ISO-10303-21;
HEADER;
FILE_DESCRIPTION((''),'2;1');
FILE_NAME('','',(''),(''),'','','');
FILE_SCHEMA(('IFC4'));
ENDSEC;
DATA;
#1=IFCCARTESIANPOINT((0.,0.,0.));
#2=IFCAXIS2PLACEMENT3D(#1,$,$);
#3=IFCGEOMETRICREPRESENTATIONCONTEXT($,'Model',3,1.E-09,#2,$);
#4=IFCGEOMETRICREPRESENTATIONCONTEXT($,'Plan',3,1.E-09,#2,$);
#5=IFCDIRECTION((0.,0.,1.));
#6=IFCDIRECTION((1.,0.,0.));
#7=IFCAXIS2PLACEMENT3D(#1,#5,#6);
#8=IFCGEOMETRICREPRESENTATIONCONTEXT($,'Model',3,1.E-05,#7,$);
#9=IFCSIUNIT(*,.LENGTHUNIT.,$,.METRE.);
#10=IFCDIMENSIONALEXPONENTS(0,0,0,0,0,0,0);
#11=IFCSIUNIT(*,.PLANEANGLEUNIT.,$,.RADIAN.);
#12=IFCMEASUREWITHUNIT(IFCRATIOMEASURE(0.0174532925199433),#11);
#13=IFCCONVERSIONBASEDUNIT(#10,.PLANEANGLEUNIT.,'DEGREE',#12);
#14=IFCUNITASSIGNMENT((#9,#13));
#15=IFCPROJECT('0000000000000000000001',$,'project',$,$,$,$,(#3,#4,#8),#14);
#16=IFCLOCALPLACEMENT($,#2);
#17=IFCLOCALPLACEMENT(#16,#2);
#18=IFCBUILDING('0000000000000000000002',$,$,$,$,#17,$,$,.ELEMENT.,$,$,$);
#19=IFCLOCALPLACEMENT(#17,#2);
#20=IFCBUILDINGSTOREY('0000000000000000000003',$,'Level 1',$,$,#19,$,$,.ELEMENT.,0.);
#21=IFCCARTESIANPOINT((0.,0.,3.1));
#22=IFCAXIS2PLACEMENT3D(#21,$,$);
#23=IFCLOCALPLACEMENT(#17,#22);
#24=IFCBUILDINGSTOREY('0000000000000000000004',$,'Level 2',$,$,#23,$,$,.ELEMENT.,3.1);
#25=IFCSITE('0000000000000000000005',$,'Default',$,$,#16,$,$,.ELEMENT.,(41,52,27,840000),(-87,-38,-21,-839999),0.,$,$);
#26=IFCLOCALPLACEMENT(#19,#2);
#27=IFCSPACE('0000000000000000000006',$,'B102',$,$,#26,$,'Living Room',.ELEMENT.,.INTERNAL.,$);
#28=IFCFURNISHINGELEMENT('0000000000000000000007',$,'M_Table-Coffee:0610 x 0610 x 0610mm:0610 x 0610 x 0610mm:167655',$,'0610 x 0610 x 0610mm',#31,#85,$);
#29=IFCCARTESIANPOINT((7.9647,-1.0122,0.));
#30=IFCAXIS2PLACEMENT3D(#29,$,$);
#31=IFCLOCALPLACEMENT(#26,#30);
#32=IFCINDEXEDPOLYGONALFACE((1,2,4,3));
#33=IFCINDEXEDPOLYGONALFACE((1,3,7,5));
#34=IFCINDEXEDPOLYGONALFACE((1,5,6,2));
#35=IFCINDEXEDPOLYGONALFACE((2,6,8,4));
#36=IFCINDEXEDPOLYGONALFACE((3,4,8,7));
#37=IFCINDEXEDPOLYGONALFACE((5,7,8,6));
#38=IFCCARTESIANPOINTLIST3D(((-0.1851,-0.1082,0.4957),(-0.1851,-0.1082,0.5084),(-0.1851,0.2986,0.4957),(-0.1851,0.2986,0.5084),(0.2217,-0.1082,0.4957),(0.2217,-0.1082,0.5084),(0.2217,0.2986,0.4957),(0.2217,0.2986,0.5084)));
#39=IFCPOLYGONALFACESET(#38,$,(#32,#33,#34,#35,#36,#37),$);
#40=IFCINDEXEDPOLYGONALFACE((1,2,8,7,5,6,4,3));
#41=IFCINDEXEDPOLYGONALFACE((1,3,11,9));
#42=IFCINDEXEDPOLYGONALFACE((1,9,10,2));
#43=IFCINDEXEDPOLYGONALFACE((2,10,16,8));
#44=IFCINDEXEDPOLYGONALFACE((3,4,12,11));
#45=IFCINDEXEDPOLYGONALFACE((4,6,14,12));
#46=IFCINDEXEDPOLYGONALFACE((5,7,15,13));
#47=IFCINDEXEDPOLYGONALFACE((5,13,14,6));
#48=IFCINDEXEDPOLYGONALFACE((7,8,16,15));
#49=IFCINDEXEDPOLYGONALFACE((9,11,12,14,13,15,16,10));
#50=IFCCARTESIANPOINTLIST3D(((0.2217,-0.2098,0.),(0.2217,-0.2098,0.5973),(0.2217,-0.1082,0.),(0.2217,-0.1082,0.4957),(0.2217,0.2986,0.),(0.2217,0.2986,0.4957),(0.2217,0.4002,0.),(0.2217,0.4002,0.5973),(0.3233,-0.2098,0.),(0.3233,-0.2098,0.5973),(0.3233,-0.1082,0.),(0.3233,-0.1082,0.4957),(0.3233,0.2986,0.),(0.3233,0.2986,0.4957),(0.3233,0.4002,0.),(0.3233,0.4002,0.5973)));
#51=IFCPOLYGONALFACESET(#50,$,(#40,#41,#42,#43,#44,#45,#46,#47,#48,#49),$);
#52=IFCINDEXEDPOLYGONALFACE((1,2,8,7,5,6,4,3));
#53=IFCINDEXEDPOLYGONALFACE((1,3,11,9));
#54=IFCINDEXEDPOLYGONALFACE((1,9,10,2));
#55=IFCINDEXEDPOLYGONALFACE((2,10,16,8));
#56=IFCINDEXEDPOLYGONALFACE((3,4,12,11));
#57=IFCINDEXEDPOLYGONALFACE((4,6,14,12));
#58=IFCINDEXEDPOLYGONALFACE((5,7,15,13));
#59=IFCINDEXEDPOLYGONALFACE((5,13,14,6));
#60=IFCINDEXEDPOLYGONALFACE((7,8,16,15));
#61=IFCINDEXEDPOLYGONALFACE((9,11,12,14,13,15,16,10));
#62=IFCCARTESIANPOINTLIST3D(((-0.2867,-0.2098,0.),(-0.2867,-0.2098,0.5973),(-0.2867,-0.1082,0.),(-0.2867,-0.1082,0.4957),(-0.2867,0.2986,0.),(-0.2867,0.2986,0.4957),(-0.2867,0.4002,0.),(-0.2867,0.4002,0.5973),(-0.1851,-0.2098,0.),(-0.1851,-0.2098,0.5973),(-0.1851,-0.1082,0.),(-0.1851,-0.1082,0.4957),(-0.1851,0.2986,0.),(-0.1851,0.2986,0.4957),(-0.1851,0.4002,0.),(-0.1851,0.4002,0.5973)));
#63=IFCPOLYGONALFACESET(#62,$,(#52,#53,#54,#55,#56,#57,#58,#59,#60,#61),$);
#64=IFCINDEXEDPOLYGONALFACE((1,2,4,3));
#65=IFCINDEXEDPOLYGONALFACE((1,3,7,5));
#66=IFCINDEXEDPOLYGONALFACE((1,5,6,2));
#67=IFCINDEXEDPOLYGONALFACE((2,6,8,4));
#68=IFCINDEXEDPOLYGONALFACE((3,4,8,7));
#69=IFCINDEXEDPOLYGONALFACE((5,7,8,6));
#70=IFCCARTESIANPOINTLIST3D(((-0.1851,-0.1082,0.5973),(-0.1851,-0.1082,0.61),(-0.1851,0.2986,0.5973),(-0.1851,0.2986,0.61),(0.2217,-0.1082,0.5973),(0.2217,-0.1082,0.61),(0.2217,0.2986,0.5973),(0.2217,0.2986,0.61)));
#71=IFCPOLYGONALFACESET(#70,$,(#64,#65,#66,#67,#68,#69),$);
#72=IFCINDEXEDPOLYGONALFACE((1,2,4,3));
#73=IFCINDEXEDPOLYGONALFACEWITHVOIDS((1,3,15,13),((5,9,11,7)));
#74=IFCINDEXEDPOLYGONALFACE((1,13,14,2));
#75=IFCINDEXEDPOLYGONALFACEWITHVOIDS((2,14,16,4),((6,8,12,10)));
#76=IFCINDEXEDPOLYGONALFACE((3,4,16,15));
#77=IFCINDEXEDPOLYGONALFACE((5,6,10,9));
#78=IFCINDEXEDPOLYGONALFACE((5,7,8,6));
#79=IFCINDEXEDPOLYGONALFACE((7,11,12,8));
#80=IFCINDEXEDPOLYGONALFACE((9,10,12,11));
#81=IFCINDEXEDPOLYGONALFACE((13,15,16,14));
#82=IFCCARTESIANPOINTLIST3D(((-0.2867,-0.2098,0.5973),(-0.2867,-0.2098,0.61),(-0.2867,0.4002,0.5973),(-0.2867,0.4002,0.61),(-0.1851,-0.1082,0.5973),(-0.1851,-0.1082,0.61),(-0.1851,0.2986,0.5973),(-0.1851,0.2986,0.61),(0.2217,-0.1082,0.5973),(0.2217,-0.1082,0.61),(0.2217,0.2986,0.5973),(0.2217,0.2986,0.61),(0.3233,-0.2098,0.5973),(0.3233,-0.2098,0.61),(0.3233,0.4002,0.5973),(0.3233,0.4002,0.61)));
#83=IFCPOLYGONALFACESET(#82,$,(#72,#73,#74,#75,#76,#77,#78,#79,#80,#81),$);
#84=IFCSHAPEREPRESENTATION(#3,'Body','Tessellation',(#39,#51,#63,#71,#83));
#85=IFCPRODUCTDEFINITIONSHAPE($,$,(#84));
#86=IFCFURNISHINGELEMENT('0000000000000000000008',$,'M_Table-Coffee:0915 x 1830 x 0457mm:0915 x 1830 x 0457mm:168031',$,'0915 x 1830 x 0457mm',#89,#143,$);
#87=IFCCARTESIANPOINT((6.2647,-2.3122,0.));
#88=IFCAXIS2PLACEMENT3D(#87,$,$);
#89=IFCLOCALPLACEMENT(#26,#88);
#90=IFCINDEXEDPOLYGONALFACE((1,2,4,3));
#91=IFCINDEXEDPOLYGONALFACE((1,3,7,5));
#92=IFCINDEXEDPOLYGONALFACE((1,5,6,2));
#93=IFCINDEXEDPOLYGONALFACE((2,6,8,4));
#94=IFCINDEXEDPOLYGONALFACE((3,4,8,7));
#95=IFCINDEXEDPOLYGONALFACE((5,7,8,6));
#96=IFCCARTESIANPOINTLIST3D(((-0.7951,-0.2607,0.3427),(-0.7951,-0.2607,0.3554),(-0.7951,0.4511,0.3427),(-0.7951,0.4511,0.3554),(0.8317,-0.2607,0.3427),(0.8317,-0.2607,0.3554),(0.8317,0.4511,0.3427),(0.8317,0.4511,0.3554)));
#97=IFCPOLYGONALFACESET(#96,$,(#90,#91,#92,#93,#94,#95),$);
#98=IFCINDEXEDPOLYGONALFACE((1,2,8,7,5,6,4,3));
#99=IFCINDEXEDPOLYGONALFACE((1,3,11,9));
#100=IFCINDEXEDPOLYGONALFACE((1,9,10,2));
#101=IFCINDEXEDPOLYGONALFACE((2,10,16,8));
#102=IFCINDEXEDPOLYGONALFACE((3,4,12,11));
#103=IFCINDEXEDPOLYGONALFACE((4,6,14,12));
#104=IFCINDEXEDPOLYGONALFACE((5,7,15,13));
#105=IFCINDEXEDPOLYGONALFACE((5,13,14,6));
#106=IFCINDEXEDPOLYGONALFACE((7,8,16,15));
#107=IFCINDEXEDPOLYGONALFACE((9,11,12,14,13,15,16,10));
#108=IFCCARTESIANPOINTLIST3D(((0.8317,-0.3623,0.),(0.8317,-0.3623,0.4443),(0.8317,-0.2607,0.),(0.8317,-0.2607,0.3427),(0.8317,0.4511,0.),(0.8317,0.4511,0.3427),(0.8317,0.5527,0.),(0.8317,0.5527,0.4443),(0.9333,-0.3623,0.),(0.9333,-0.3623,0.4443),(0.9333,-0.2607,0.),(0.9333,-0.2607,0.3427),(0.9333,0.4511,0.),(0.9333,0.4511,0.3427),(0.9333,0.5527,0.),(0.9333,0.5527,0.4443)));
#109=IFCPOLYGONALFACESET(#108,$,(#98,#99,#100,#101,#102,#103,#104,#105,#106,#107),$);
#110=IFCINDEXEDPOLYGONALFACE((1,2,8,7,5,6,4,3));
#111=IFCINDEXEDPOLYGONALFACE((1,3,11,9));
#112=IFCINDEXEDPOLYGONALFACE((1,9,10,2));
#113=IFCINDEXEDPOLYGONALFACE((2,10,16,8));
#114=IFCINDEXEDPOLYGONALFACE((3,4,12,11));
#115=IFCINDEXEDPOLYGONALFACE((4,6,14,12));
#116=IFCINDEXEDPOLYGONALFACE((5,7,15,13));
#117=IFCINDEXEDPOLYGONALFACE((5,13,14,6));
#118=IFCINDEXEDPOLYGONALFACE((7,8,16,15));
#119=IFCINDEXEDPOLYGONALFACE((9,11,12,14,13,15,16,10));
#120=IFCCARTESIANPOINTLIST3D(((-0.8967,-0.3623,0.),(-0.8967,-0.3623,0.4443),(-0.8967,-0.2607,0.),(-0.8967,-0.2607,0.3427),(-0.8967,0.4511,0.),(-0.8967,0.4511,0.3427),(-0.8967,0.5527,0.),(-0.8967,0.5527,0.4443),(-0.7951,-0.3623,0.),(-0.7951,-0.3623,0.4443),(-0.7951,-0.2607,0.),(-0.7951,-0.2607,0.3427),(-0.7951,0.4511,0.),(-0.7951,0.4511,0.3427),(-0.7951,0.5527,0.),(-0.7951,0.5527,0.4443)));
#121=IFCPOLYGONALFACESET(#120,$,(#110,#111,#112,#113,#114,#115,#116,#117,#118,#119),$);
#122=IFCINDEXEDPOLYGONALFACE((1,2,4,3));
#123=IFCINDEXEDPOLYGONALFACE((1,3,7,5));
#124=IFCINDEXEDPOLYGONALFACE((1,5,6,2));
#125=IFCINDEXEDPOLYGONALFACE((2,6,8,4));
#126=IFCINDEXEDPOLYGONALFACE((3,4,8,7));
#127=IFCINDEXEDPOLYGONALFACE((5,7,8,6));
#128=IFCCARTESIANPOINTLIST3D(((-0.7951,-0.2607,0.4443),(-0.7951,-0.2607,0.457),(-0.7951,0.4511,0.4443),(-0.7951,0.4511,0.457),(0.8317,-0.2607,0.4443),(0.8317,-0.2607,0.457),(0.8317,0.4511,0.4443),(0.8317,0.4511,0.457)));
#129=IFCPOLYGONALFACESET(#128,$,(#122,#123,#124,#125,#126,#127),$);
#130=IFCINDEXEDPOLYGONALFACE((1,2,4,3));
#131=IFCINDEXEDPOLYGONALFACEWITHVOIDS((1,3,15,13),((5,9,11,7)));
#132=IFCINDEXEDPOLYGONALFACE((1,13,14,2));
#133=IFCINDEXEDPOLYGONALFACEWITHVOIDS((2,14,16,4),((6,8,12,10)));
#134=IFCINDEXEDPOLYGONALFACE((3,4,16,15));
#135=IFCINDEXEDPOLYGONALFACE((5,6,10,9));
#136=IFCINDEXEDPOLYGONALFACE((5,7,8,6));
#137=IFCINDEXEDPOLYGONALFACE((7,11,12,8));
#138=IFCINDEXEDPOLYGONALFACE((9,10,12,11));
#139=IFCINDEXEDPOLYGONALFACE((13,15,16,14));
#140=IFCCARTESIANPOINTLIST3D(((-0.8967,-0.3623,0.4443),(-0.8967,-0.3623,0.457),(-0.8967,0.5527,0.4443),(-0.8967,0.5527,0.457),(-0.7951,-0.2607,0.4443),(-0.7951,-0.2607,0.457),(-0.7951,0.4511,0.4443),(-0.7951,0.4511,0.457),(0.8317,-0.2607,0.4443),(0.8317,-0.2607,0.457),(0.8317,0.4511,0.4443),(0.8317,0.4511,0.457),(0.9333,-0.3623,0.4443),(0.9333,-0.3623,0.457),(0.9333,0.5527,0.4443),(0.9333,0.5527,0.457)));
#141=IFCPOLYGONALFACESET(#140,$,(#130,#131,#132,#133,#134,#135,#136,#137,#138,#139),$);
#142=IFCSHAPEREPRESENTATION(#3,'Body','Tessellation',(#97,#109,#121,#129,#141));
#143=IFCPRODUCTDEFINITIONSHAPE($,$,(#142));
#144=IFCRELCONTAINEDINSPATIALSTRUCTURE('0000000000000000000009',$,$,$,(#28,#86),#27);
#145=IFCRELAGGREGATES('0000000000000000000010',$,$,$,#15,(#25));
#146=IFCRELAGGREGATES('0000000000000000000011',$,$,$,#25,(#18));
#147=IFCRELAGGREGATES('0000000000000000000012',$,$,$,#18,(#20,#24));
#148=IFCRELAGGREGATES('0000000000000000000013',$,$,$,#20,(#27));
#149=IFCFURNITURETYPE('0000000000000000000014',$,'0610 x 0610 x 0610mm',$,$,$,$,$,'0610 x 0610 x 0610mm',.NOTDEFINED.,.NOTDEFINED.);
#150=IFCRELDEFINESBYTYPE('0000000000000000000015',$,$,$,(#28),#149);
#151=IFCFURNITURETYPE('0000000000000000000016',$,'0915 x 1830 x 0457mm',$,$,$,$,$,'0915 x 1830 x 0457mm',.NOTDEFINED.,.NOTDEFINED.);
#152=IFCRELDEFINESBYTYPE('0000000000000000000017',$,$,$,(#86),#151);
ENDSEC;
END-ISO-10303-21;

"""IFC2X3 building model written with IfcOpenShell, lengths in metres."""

from ifc_helpers import new_model, entity, si_unit, converted_unit, frame, origin, origin_with_axes, origin_2d_with_axis, place, context, project, spatial, polyline, rectangle, outline, extrude, source, transform, mapped, type_object, type_shapes, element, save


model = new_model("IFC2X3")

# Units and contexts
model_context_1 = context("Model", 3, precision=1e-09, world=origin())
plan_context = context("Plan", 3, precision=1e-09, world=origin())
model_context_2 = context("Model", 3, precision=1e-05, world=origin_with_axes())
ifc_project = project(units=[si_unit("LENGTHUNIT", "METRE"), converted_unit("PLANEANGLEUNIT", "DEGREE", entity("IfcRatioMeasure", 0.0174532925199433), si_unit("PLANEANGLEUNIT", "RADIAN"), dimensions=[0, 0, 0, 0, 0, 0, 0])], contexts=[model_context_1, plan_context, model_context_2])

# Site, building, storey
site_placement = place(None, origin())
site = spatial("IfcSite", under=ifc_project, at=site_placement, Name="Default", CompositionType="ELEMENT", RefLatitude=(41, 52, 27, 840000), RefLongitude=(-87, -38, -21, -839999), RefElevation=0.0)
building_placement = place(site_placement, origin())
building = spatial("IfcBuilding", under=site, at=building_placement, CompositionType="ELEMENT")
storey_1_placement = place(building_placement, origin())
storey_1 = spatial("IfcBuildingStorey", under=building, at=storey_1_placement, Name="Level 1", CompositionType="ELEMENT", Elevation=0.0)

# Shared definitions
storey_2_placement = place(building_placement, frame((0.0, 0.0, 3.1)))
storey_2 = spatial("IfcBuildingStorey", under=building, at=storey_2_placement, Name="Level 2", CompositionType="ELEMENT", Elevation=3.1)

# Shared definitions
space_1_placement = place(storey_1_placement, origin())
space_1 = spatial("IfcSpace", under=storey_1, at=space_1_placement, Name="B102", LongName="Living Room", CompositionType="ELEMENT", InteriorOrExteriorSpace="INTERNAL")

# Furnishing elements
furniture_type_1 = type_object("IfcFurnitureType", Name="0610 x 0610 x 0610mm", ElementType="0610 x 0610 x 0610mm", AssemblyPlace="NOTDEFINED")
shared_shape_1 = source(origin(), model_context_1, "Body", "SweptSolid", [
    extrude(rectangle(XDim=0.4068, YDim=0.4068, at=origin_2d_with_axis()), frame((0.0183, 0.0952, 0.4957), z_axis=(0.0, 0.0, 1.0), x_axis=(-1.0, 0.0, 0.0)), (0.0, 0.0, 1.0), 0.0127),
    extrude(outline(polyline([(-0.2732, -0.305), (0.324, -0.305), (0.324, 0.305), (-0.2732, 0.305), (-0.2732, 0.2034), (0.2225, 0.2034), (0.2225, -0.2034), (-0.2732, -0.2034), (-0.2732, -0.305)])), frame((0.2217, 0.0952, 0.2732), z_axis=(1.0, 0.0, 0.0), x_axis=(0.0, 0.0, 1.0)), (0.0, 0.0, 1.0), 0.1016),
    extrude(outline(polyline([(-0.305, -0.3241), (0.305, -0.3241), (0.305, 0.2733), (0.2034, 0.2733), (0.2034, -0.2224), (-0.2034, -0.2224), (-0.2034, 0.2733), (-0.305, 0.2733), (-0.305, -0.3241)])), frame((-0.2867, 0.0952, 0.2733), z_axis=(1.0, 0.0, 0.0), x_axis=(0.0, -1.0, 0.0)), (0.0, 0.0, 1.0), 0.1016),
    extrude(rectangle(XDim=0.4068, YDim=0.4068, at=origin_2d_with_axis()), frame((0.0183, 0.0952, 0.5973), z_axis=(0.0, 0.0, 1.0), x_axis=(-1.0, 0.0, 0.0)), (0.0, 0.0, 1.0), 0.0127),
    extrude(outline(polyline([(-0.305, -0.305), (0.305, -0.305), (0.305, 0.305), (-0.305, 0.305), (-0.305, -0.305)]), holes=[polyline([(-0.2034, -0.2034), (-0.2034, 0.2034), (0.2034, 0.2034), (0.2034, -0.2034), (-0.2034, -0.2034)])]), frame((0.0183, 0.0952, 0.5973), z_axis=(0.0, 0.0, 1.0), x_axis=(-1.0, 0.0, 0.0)), (0.0, 0.0, 1.0), 0.0127),
])
type_shapes(furniture_type_1, [shared_shape_1])
for number, where, name in (
    (1, (7.9647, -1.0122, 0.0), "M_Table-Coffee:0610 x 0610 x 0610mm:0610 x 0610 x 0610mm:167655"),
):
    element("IfcFurnishingElement", number, at=place(space_1_placement, frame(where)), inside=space_1, type_object=furniture_type_1, Name=name, ObjectType="0610 x 0610 x 0610mm", context=model_context_1, shape_type="MappedRepresentation", body=[
        mapped(shared_shape_1, transform((0.0, 0.0, 0.0), scale=1.0)),
    ])
furniture_type_2 = type_object("IfcFurnitureType", Name="0915 x 1830 x 0457mm", ElementType="0915 x 1830 x 0457mm", AssemblyPlace="NOTDEFINED")
shared_shape_2 = source(origin(), model_context_1, "Body", "SweptSolid", [
    extrude(rectangle(XDim=1.6268, YDim=0.7118, at=origin_2d_with_axis()), frame((0.0183, 0.0952, 0.3427), z_axis=(0.0, 0.0, 1.0), x_axis=(-1.0, 0.0, 0.0)), (0.0, 0.0, 1.0), 0.0127),
    extrude(outline(polyline([(-0.1967, -0.4575), (0.2475, -0.4575), (0.2475, 0.4575), (-0.1967, 0.4575), (-0.1967, 0.3559), (0.146, 0.3559), (0.146, -0.3559), (-0.1967, -0.3559), (-0.1967, -0.4575)])), frame((0.8317, 0.0952, 0.1967), z_axis=(1.0, 0.0, 0.0), x_axis=(0.0, 0.0, 1.0)), (0.0, 0.0, 1.0), 0.1016),
    extrude(outline(polyline([(-0.4575, -0.2476), (0.4575, -0.2476), (0.4575, 0.1968), (0.3559, 0.1968), (0.3559, -0.1459), (-0.3559, -0.1459), (-0.3559, 0.1968), (-0.4575, 0.1968), (-0.4575, -0.2476)])), frame((-0.8967, 0.0952, 0.1968), z_axis=(1.0, 0.0, 0.0), x_axis=(0.0, -1.0, 0.0)), (0.0, 0.0, 1.0), 0.1016),
    extrude(rectangle(XDim=1.6268, YDim=0.7118, at=origin_2d_with_axis()), frame((0.0183, 0.0952, 0.4443), z_axis=(0.0, 0.0, 1.0), x_axis=(-1.0, 0.0, 0.0)), (0.0, 0.0, 1.0), 0.0127),
    extrude(outline(polyline([(-0.915, -0.4575), (0.915, -0.4575), (0.915, 0.4575), (-0.915, 0.4575), (-0.915, -0.4575)]), holes=[polyline([(-0.8134, -0.3559), (-0.8134, 0.3559), (0.8134, 0.3559), (0.8134, -0.3559), (-0.8134, -0.3559)])]), frame((0.0183, 0.0952, 0.4443), z_axis=(0.0, 0.0, 1.0), x_axis=(-1.0, 0.0, 0.0)), (0.0, 0.0, 1.0), 0.0127),
])
type_shapes(furniture_type_2, [shared_shape_2])
furnishing_1_placement = place(space_1_placement, frame((6.2647, -2.3122, 0.0)))
element("IfcFurnishingElement", 2, at=furnishing_1_placement, inside=space_1, type_object=furniture_type_2, Name="M_Table-Coffee:0915 x 1830 x 0457mm:0915 x 1830 x 0457mm:168031", ObjectType="0915 x 1830 x 0457mm", context=model_context_1, shape_type="MappedRepresentation", body=[
    mapped(shared_shape_2, transform((0.0, 0.0, 0.0), scale=1.0)),
])

save(model, "model.ifc")
